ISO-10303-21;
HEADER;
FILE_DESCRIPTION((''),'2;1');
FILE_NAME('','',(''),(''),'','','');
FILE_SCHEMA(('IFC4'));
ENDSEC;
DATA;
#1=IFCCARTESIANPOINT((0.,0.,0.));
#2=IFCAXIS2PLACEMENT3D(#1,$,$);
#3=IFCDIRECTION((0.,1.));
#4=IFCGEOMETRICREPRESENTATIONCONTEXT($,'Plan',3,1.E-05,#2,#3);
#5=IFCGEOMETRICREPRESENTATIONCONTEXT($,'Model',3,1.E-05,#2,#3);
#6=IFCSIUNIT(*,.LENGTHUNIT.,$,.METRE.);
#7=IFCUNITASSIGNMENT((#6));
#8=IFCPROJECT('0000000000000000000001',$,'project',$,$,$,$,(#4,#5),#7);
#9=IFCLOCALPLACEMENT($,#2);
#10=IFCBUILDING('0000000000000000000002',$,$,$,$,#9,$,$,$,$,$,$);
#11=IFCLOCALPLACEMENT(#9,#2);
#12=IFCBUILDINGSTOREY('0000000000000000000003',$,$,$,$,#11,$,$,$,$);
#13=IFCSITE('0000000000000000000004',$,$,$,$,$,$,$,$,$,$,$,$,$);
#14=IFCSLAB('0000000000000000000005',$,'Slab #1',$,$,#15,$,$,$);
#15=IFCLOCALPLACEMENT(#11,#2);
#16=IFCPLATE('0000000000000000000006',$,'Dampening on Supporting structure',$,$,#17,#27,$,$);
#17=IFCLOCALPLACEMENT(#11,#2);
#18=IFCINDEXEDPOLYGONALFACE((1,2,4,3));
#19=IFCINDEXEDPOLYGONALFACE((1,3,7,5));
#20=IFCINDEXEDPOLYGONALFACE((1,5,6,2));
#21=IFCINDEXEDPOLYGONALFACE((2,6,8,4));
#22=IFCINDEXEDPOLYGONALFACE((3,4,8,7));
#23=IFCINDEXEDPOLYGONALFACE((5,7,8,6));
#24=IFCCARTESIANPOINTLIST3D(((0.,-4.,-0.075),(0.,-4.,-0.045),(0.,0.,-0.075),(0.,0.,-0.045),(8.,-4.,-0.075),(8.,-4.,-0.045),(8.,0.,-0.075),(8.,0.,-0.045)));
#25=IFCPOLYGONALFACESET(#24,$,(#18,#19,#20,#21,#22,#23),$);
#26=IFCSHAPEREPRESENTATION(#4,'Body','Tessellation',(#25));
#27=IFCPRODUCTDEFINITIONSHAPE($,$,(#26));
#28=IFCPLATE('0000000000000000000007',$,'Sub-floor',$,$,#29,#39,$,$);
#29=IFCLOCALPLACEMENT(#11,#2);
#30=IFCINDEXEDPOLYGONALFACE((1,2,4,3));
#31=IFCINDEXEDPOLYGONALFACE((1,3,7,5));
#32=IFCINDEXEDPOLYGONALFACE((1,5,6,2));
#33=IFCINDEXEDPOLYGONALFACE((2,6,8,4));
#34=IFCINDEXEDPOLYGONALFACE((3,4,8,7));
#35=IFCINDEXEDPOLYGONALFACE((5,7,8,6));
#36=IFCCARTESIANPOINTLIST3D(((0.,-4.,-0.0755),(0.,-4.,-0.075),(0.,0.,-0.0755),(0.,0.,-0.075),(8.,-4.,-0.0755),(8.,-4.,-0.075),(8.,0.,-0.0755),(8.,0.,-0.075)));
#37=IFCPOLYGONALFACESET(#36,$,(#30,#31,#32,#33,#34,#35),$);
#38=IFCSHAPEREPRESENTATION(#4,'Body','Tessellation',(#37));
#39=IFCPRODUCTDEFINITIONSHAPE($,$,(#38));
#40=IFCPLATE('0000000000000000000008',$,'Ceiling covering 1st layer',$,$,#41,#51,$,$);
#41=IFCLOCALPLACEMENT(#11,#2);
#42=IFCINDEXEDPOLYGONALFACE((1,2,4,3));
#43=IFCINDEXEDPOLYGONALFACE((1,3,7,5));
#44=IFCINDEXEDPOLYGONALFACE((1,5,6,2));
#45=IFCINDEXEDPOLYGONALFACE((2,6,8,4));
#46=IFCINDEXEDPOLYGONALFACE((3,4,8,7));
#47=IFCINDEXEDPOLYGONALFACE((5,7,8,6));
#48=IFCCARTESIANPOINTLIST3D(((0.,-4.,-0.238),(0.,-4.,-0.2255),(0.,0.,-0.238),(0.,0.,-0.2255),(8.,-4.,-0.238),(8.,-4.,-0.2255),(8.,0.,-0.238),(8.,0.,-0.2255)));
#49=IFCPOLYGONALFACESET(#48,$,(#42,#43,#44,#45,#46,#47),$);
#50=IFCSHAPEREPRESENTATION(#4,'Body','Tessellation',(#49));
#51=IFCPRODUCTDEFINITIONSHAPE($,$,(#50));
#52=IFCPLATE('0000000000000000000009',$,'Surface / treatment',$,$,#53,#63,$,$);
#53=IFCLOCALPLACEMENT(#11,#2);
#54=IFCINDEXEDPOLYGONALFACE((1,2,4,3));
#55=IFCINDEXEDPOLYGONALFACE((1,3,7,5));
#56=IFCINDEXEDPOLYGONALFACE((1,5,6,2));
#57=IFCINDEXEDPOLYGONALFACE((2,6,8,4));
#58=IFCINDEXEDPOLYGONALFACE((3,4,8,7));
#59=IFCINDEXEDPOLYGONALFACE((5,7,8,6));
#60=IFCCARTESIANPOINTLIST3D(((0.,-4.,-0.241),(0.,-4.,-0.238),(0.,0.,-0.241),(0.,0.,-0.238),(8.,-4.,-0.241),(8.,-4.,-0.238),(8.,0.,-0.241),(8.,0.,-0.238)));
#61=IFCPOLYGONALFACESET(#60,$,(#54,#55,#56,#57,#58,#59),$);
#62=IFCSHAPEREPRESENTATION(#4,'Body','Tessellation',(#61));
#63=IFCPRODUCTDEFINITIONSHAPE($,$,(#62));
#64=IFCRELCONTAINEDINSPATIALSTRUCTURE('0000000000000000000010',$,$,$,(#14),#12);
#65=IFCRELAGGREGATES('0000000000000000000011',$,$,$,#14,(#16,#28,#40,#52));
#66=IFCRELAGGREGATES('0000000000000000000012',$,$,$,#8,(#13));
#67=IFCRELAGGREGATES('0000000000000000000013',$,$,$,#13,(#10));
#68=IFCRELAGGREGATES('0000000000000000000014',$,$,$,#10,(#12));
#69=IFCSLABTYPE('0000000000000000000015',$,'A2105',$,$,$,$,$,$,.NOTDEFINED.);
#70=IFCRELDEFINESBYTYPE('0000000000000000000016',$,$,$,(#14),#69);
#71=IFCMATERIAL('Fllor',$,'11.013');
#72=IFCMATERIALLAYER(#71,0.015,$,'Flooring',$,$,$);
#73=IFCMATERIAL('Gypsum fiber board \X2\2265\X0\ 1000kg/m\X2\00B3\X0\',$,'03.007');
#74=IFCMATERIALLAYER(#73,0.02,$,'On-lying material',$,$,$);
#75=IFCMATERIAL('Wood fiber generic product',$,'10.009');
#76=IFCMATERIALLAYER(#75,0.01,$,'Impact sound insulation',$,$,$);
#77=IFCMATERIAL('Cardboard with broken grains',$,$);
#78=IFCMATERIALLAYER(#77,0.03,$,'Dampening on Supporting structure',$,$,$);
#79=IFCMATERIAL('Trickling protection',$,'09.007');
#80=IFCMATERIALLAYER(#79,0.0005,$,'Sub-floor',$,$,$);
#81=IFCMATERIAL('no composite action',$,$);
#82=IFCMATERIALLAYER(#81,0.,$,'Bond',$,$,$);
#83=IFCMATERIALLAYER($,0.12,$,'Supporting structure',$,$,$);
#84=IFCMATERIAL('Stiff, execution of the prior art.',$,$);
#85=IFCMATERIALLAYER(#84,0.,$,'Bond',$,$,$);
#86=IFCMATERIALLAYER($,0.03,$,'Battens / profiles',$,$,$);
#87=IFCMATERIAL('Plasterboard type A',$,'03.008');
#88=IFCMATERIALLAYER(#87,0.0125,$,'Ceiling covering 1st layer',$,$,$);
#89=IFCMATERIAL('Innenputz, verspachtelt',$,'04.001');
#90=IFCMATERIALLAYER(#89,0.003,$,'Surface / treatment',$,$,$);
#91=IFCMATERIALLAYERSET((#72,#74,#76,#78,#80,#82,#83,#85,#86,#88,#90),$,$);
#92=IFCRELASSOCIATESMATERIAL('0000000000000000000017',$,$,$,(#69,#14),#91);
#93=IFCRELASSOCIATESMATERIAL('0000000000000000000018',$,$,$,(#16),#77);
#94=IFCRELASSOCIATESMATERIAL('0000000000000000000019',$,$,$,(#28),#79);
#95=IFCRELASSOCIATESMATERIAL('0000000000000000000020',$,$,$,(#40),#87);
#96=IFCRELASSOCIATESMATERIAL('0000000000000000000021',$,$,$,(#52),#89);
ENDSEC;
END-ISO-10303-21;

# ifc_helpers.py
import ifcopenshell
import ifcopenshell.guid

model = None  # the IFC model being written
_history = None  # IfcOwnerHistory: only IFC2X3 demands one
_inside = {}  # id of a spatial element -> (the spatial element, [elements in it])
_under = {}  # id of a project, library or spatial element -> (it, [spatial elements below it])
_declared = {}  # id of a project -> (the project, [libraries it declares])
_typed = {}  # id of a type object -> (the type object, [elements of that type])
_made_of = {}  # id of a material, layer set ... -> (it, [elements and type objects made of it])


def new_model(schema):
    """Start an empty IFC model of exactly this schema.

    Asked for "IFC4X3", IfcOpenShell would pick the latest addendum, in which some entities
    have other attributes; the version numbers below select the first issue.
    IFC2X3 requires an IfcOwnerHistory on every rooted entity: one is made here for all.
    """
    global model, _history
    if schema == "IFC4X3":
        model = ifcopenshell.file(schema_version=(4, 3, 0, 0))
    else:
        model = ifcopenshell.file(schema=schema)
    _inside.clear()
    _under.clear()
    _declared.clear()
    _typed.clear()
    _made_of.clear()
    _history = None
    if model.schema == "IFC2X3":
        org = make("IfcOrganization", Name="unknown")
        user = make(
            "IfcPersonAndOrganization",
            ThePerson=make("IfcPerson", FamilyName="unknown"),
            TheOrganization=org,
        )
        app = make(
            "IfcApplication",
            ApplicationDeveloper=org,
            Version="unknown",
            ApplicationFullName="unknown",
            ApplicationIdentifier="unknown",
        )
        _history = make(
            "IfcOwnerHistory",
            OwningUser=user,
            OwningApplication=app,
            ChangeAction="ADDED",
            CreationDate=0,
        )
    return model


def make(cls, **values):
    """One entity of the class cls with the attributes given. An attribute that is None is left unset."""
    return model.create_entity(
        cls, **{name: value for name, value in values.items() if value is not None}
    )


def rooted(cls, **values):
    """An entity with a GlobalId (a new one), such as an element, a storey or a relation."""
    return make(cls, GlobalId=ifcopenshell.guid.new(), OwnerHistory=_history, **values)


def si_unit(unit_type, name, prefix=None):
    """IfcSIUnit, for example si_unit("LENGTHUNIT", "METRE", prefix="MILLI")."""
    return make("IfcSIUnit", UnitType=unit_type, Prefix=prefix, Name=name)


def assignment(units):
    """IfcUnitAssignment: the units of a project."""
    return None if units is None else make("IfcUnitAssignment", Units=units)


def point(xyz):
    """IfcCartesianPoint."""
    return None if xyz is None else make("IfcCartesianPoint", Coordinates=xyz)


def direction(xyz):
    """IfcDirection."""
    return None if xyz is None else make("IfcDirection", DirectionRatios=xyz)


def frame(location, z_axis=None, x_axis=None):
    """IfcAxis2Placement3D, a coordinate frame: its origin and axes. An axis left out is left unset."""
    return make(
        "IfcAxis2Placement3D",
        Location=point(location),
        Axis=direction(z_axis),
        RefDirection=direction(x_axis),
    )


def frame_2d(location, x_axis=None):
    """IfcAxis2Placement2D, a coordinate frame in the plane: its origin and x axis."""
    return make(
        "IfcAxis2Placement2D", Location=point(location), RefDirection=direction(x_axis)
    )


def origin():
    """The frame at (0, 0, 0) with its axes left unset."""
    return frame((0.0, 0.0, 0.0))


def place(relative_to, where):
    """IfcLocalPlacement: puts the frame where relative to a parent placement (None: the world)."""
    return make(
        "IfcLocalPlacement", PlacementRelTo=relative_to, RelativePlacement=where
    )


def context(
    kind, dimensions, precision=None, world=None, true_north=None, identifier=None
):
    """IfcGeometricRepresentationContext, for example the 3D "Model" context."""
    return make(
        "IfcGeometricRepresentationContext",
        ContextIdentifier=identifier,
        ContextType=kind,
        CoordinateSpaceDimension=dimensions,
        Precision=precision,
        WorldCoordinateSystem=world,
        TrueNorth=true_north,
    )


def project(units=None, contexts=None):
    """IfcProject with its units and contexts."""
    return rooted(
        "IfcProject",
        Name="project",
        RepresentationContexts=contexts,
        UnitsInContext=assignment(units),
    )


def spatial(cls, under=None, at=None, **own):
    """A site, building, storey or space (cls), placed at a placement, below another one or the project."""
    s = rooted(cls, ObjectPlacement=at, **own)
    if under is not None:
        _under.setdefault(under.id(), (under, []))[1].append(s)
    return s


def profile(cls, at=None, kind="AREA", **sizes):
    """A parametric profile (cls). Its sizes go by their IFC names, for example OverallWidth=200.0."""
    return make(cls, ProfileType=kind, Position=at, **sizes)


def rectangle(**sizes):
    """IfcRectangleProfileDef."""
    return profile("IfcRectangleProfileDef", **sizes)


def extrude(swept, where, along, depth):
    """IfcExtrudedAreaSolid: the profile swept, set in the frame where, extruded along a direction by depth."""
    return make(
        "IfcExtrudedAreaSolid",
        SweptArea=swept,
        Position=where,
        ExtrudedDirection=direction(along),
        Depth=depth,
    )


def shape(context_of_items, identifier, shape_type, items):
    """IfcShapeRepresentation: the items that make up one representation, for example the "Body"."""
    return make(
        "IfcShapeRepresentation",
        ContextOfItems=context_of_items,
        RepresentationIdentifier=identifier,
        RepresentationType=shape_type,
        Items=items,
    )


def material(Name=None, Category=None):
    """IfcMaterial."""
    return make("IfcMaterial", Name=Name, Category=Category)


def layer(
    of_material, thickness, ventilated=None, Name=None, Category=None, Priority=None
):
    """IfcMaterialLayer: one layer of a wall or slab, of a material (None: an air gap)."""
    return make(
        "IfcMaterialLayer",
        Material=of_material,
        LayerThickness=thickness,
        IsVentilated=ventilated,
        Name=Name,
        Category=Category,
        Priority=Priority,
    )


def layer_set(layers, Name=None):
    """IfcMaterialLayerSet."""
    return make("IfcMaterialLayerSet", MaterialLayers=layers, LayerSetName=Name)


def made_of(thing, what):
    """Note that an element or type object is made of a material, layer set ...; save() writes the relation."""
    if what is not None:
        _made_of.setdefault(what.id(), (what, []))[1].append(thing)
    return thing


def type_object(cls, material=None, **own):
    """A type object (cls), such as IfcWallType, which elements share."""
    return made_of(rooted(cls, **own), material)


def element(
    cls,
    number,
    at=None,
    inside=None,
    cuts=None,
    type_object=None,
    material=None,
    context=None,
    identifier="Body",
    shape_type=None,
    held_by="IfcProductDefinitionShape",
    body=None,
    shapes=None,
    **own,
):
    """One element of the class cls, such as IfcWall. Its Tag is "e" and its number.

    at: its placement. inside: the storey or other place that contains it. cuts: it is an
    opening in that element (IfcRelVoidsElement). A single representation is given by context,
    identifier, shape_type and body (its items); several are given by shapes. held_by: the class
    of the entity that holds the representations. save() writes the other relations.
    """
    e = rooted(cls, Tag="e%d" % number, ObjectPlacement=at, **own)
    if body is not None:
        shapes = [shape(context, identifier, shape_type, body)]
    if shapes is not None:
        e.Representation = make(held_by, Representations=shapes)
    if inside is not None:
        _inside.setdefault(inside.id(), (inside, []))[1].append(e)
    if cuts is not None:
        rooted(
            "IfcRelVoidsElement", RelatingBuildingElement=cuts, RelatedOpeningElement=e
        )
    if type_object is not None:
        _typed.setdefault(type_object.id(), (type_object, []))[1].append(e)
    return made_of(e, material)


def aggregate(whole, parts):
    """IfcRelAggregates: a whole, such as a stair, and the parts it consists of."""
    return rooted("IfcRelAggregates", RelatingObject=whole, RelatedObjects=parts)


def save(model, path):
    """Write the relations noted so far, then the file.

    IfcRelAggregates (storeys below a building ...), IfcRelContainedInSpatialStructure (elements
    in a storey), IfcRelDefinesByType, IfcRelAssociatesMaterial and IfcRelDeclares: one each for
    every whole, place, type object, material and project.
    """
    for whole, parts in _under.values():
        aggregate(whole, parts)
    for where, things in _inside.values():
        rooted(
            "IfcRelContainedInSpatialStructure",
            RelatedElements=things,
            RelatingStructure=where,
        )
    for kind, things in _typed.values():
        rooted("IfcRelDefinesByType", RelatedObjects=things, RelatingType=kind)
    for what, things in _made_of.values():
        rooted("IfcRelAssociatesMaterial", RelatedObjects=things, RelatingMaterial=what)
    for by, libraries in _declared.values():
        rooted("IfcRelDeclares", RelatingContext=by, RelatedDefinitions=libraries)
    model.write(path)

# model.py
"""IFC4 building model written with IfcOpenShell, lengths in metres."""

from ifc_helpers import new_model, si_unit, direction, frame, frame_2d, origin, place, context, project, spatial, rectangle, extrude, material, layer, layer_set, type_object, element, aggregate, save


model = new_model("IFC4")

# Units and contexts
plan_context = context("Plan", 3, precision=1e-05, world=origin(), true_north=direction((0.0, 1.0)))
model_context = context("Model", 3, precision=1e-05, world=origin(), true_north=direction((0.0, 1.0)))
ifc_project = project(units=[si_unit("LENGTHUNIT", "METRE")], contexts=[plan_context, model_context])

# Site, building, storey
site = spatial("IfcSite", under=ifc_project)
building_placement = place(None, origin())
building = spatial("IfcBuilding", under=site, at=building_placement)
storey_placement = place(building_placement, origin())
storey = spatial("IfcBuildingStorey", under=building, at=storey_placement)

# Slab, plates
ifc_material_1 = material(Name="Fllor", Category="11.013")
ifc_layer_1 = layer(ifc_material_1, 0.015, Name="Flooring")
ifc_material_2 = material(Name="Gypsum fiber board ≥ 1000kg/m³", Category="03.007")
ifc_layer_2 = layer(ifc_material_2, 0.02, Name="On-lying material")
ifc_material_3 = material(Name="Wood fiber generic product", Category="10.009")
ifc_layer_3 = layer(ifc_material_3, 0.01, Name="Impact sound insulation")
ifc_material_4 = material(Name="Cardboard with broken grains")
ifc_layer_4 = layer(ifc_material_4, 0.03, Name="Dampening on Supporting structure")
ifc_material_5 = material(Name="Trickling protection", Category="09.007")
ifc_layer_5 = layer(ifc_material_5, 0.0005, Name="Sub-floor")
ifc_material_6 = material(Name="no composite action")
ifc_layer_6 = layer(ifc_material_6, 0.0, Name="Bond")
ifc_layer_7 = layer(None, 0.12, Name="Supporting structure")
ifc_material_7 = material(Name="Stiff, execution of the prior art.")
ifc_layer_8 = layer(ifc_material_7, 0.0, Name="Bond")
ifc_layer_9 = layer(None, 0.03, Name="Battens / profiles")
ifc_material_8 = material(Name="Plasterboard type A", Category="03.008")
ifc_layer_10 = layer(ifc_material_8, 0.0125, Name="Ceiling covering 1st layer")
ifc_material_9 = material(Name="Innenputz, verspachtelt", Category="04.001")
ifc_layer_11 = layer(ifc_material_9, 0.003, Name="Surface / treatment")
ifc_layer_set = layer_set([ifc_layer_1, ifc_layer_2, ifc_layer_3, ifc_layer_4, ifc_layer_5, ifc_layer_6, ifc_layer_7, ifc_layer_8, ifc_layer_9, ifc_layer_10, ifc_layer_11])
slab_type = type_object("IfcSlabType", Name="A2105", PredefinedType="NOTDEFINED", material=ifc_layer_set)
slab_placement = place(None, frame((0.0, 0.0, 0.0), z_axis=(0.0, 0.0, -1.0), x_axis=(1.0, 0.0, 0.0)))
slab = element("IfcSlab", 1, at=slab_placement, inside=storey, type_object=slab_type, material=ifc_layer_set, Name="Slab #1")
plate_1_placement = place(slab_placement, origin())
plate_1 = element("IfcPlate", 2, at=plate_1_placement, material=ifc_material_4, Name="Dampening on Supporting structure", context=plan_context, shape_type="SweptSolid", body=[
    extrude(rectangle(XDim=8.0, YDim=4.0, at=frame_2d((4.0, 2.0), x_axis=(1.0, 0.0))), frame((0.0, 0.0, 0.045), z_axis=(0.0, 0.0, 1.0), x_axis=(1.0, 0.0, 0.0)), (0.0, 0.0, 1.0), 0.03),
])
plate_2_placement = place(slab_placement, origin())
plate_2 = element("IfcPlate", 3, at=plate_2_placement, material=ifc_material_5, Name="Sub-floor", context=plan_context, shape_type="SweptSolid", body=[
    extrude(rectangle(XDim=8.0, YDim=4.0, at=frame_2d((4.0, 2.0), x_axis=(1.0, 0.0))), frame((0.0, 0.0, 0.075), z_axis=(0.0, 0.0, 1.0), x_axis=(1.0, 0.0, 0.0)), (0.0, 0.0, 1.0), 0.0005),
])
plate_3_placement = place(slab_placement, origin())
plate_3 = element("IfcPlate", 4, at=plate_3_placement, material=ifc_material_8, Name="Ceiling covering 1st layer", context=plan_context, shape_type="SweptSolid", body=[
    extrude(rectangle(XDim=8.0, YDim=4.0, at=frame_2d((4.0, 2.0), x_axis=(1.0, 0.0))), frame((0.0, 0.0, 0.2255), z_axis=(0.0, 0.0, 1.0), x_axis=(1.0, 0.0, 0.0)), (0.0, 0.0, 1.0), 0.0125),
])
plate_4_placement = place(slab_placement, origin())
plate_4 = element("IfcPlate", 5, at=plate_4_placement, material=ifc_material_9, Name="Surface / treatment", context=plan_context, shape_type="SweptSolid", body=[
    extrude(rectangle(XDim=8.0, YDim=4.0, at=frame_2d((4.0, 2.0), x_axis=(1.0, 0.0))), frame((0.0, 0.0, 0.238), z_axis=(0.0, 0.0, 1.0), x_axis=(1.0, 0.0, 0.0)), (0.0, 0.0, 1.0), 0.003),
])
aggregate(slab, [plate_1, plate_2, plate_3, plate_4])

save(model, "model.ifc")
